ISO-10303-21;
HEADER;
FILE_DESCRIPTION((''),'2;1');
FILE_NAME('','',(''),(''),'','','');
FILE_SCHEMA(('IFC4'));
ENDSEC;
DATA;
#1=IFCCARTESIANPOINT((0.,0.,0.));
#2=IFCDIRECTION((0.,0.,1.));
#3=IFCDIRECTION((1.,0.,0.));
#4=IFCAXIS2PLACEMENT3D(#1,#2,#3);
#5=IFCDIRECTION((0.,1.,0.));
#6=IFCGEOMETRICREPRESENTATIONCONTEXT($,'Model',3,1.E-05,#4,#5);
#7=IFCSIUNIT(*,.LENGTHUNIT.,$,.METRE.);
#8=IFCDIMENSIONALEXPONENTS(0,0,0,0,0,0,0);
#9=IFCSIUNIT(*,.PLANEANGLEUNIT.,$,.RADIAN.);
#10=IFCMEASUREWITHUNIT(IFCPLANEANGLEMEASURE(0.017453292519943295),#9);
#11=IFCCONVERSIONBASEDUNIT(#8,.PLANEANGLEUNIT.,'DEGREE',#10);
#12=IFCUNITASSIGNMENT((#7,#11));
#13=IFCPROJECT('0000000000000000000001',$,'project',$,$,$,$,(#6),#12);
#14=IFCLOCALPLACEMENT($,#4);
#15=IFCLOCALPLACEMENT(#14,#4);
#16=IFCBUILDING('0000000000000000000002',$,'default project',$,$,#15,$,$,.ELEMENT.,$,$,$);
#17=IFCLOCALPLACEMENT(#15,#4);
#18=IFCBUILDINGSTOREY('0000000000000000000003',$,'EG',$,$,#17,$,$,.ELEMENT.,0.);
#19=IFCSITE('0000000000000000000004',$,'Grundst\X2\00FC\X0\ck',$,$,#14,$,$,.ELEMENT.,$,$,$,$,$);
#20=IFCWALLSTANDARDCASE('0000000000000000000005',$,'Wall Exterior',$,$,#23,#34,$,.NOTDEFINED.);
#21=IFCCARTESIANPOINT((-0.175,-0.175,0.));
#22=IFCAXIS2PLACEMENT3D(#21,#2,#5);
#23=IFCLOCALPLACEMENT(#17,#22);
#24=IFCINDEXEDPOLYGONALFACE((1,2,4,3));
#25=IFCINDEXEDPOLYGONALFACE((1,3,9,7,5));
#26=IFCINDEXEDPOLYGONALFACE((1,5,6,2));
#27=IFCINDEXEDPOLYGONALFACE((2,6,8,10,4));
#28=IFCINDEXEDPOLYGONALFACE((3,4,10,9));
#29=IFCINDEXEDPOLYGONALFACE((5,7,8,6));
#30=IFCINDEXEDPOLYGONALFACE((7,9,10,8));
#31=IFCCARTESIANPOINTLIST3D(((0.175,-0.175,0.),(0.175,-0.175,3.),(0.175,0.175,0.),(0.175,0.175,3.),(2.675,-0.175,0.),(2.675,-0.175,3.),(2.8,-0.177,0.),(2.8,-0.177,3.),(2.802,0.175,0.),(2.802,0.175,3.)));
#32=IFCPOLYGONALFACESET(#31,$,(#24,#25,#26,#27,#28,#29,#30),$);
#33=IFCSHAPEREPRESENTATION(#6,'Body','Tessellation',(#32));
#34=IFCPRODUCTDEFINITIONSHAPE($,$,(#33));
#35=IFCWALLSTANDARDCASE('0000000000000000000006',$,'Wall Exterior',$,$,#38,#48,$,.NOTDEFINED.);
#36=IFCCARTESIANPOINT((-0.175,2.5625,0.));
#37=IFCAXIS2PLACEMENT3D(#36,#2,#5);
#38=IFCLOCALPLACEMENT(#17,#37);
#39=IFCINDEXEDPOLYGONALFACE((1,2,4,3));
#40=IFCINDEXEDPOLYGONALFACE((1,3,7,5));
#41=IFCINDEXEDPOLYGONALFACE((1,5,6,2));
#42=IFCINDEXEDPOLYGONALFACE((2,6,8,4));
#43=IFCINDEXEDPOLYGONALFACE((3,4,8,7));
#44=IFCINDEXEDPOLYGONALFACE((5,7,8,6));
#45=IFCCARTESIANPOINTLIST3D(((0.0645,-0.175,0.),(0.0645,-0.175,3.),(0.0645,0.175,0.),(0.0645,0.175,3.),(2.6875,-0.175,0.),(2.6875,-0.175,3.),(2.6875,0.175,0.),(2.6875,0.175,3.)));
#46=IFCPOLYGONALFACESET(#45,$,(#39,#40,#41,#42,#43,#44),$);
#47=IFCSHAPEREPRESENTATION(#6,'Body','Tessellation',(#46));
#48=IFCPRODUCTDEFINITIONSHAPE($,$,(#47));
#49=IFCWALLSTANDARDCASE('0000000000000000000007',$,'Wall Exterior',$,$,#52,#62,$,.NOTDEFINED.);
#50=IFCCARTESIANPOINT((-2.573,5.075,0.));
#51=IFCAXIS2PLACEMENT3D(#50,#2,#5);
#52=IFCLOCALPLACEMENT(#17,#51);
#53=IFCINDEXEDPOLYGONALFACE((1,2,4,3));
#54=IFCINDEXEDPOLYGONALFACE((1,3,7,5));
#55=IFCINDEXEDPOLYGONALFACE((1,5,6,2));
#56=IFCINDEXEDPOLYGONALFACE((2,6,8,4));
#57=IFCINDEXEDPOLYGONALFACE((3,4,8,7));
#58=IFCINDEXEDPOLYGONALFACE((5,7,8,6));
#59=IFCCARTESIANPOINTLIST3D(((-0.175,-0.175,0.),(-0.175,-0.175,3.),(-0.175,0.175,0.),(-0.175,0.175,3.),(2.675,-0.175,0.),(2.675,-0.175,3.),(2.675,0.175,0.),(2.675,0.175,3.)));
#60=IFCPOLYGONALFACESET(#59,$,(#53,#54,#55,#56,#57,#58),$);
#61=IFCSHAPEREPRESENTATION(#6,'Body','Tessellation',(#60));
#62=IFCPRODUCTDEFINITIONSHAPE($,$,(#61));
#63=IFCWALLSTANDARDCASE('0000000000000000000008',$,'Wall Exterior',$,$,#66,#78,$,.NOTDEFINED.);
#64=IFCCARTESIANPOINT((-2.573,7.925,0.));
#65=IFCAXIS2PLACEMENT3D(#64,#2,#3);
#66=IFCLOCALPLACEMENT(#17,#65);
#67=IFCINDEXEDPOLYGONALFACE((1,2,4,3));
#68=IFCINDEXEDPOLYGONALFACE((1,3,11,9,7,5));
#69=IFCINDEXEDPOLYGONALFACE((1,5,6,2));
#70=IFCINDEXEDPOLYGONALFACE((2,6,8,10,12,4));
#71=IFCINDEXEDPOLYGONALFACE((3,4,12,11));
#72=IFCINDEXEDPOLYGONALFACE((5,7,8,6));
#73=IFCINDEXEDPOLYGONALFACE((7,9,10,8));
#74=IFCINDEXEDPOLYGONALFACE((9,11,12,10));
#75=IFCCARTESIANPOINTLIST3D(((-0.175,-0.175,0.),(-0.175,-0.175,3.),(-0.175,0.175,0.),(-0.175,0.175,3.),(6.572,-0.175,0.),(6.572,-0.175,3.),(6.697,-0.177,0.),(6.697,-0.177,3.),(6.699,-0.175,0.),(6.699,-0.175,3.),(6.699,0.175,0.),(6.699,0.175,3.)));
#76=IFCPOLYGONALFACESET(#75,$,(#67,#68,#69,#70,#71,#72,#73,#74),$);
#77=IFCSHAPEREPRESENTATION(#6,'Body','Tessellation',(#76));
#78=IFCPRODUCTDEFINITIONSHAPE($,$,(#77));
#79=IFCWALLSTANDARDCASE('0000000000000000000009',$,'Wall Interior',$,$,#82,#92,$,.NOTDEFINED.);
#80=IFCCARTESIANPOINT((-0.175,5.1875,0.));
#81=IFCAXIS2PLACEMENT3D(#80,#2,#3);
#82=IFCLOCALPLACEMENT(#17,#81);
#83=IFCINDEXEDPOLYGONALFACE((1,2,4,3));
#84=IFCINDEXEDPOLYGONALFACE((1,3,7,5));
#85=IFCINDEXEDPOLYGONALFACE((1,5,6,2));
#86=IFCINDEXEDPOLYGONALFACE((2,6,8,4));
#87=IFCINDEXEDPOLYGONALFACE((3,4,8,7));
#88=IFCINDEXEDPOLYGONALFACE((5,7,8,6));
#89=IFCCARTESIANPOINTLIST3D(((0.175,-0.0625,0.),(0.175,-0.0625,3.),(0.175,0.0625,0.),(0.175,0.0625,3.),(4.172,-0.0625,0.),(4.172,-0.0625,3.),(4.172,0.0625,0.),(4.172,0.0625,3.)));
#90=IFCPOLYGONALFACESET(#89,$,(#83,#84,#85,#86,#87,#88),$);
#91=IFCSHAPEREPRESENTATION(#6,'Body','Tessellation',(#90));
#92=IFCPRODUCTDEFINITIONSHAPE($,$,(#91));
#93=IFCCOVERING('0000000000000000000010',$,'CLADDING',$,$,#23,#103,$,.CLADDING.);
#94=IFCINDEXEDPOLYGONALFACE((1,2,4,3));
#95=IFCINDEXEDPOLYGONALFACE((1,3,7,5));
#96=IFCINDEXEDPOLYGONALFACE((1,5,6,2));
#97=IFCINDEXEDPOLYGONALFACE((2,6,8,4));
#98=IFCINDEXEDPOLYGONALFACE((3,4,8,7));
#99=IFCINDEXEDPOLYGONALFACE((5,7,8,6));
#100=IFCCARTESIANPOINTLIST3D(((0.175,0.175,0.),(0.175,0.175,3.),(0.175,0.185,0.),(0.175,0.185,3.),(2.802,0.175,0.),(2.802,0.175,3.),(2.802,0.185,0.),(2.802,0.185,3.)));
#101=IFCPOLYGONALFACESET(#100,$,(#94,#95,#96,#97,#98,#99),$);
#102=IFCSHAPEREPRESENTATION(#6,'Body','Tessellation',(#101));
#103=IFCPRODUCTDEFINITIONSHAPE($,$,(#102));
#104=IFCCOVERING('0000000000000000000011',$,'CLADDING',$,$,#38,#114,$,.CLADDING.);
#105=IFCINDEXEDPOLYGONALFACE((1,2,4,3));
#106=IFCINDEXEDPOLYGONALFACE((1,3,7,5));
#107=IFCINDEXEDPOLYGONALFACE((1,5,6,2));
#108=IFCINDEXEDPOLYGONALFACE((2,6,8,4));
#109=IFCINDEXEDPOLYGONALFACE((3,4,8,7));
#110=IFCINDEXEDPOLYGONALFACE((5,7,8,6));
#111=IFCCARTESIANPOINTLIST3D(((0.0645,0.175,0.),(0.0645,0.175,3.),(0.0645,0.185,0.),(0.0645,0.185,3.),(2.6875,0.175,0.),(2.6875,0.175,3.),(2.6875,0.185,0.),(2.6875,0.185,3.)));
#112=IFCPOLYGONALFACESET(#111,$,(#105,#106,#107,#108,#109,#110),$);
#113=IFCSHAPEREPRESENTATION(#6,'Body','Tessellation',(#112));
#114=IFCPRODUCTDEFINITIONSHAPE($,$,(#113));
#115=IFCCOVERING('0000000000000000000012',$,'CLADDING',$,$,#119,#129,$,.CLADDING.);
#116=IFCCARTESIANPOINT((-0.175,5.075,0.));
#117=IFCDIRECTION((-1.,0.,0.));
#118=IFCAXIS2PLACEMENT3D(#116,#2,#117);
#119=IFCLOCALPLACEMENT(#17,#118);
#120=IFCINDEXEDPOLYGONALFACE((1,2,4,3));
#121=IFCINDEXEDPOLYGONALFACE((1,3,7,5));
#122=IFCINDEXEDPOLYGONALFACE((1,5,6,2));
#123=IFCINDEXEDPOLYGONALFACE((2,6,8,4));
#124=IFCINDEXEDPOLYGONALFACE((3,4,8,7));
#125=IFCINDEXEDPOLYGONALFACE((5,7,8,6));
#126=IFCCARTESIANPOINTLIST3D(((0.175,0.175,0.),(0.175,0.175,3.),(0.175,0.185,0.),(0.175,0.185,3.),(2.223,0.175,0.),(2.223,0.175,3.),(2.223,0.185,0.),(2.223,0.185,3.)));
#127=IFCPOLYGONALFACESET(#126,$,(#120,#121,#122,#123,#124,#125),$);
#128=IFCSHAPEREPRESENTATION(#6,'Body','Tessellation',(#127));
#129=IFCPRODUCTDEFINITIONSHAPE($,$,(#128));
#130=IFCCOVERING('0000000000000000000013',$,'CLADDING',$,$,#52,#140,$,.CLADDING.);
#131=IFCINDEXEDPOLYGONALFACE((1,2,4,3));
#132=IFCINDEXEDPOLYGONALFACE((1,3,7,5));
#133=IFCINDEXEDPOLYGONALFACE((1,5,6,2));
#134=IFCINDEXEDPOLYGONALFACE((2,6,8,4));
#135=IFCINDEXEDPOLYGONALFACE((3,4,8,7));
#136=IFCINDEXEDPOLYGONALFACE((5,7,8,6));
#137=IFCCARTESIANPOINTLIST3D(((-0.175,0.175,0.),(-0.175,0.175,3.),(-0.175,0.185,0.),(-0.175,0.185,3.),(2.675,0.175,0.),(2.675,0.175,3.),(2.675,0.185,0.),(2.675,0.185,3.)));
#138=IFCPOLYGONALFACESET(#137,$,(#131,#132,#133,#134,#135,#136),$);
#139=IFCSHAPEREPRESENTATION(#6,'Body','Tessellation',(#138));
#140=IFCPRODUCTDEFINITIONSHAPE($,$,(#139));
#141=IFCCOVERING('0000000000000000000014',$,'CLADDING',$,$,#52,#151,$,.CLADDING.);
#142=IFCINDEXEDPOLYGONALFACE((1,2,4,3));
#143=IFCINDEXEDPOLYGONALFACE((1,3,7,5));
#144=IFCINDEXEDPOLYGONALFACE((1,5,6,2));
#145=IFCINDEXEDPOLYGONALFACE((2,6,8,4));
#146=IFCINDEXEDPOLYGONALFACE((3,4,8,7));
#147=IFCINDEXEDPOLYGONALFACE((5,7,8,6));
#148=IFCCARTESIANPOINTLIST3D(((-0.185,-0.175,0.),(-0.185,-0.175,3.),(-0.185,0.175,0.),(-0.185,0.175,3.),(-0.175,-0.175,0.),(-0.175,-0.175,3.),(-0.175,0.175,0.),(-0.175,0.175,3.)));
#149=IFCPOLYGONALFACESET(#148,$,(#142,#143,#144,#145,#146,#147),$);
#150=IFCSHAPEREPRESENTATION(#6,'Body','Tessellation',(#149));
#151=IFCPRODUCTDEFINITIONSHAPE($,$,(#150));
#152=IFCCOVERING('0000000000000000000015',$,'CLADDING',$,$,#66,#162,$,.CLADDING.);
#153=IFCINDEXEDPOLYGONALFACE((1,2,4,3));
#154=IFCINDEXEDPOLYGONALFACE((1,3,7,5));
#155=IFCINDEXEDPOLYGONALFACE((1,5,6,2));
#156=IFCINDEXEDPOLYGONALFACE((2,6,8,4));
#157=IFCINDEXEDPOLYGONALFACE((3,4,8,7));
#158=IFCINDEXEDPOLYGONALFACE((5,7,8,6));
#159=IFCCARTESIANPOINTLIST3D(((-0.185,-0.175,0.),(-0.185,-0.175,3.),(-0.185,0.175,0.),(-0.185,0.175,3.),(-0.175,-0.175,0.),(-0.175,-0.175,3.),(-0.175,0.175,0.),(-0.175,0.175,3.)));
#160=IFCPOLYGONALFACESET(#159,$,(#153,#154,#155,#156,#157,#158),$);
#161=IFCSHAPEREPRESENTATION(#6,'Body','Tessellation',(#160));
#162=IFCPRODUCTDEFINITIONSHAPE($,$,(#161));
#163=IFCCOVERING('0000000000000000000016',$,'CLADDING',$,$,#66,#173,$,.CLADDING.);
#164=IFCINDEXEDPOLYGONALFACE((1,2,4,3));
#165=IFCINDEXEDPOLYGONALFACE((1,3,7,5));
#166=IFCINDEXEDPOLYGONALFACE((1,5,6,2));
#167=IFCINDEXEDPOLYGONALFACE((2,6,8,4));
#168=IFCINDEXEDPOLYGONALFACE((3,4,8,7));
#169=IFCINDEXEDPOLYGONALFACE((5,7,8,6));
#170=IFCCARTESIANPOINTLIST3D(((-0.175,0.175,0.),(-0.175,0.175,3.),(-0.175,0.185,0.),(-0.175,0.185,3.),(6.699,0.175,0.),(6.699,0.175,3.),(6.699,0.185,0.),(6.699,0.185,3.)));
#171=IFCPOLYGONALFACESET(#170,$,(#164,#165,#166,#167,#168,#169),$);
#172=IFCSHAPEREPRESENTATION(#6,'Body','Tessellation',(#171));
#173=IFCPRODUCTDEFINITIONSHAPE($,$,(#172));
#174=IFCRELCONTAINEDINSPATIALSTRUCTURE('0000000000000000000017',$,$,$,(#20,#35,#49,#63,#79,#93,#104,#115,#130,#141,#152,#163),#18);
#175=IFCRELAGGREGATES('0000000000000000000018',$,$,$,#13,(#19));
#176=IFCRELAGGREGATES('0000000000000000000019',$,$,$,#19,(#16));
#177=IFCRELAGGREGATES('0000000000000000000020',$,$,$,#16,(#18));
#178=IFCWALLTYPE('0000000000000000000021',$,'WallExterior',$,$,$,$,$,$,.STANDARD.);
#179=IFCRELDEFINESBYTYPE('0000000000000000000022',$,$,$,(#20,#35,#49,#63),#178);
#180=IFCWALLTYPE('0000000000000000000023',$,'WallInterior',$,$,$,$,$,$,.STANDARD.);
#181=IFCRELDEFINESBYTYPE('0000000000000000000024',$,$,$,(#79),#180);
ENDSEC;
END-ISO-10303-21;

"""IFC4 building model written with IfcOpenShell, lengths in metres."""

from ifc_helpers import new_model, entity, si_unit, converted_unit, direction, frame, origin_with_axes, place, context, project, spatial, polyline, outline, extrude, type_object, element, save


model = new_model("IFC4")

# Units and contexts
model_context = context("Model", 3, precision=1e-05, world=origin_with_axes(), true_north=direction((0.0, 1.0, 0.0)))
ifc_project = project(units=[si_unit("LENGTHUNIT", "METRE"), converted_unit("PLANEANGLEUNIT", "DEGREE", entity("IfcPlaneAngleMeasure", 0.017453292519943295), si_unit("PLANEANGLEUNIT", "RADIAN"), dimensions=[0, 0, 0, 0, 0, 0, 0])], contexts=[model_context])

# Site, building, storey
site_placement = place(None, origin_with_axes())
site = spatial("IfcSite", under=ifc_project, at=site_placement, Name="Grundstück", CompositionType="ELEMENT")
building_placement = place(site_placement, origin_with_axes())
building = spatial("IfcBuilding", under=site, at=building_placement, Name="default project", CompositionType="ELEMENT")
placement_1 = place(building_placement, origin_with_axes())
storey = spatial("IfcBuildingStorey", under=building, at=placement_1, Name="EG", CompositionType="ELEMENT", Elevation=0.0)

# Walls
wall_type_1 = type_object("IfcWallType", Name="WallExterior", PredefinedType="STANDARD")
placement_2 = place(placement_1, frame((-0.175, -0.175, 0.0), z_axis=(0.0, 0.0, 1.0), x_axis=(0.0, 1.0, 0.0)))
element("IfcWallStandardCase", 1, at=placement_2, inside=storey, type_object=wall_type_1, Name="Wall Exterior", PredefinedType="NOTDEFINED", context=model_context, shape_type="SweptSolid", body=[
    extrude(outline(polyline([(2.802, 0.175), (0.175, 0.175), (0.175, -0.175), (2.675, -0.175), (2.8, -0.177), (2.802, 0.175)])), origin_with_axes(), (0.0, 0.0, 1.0), 3.0),
])
placement_3 = place(placement_1, frame((-0.175, 2.5625, 0.0), z_axis=(0.0, 0.0, 1.0), x_axis=(0.0, 1.0, 0.0)))
element("IfcWallStandardCase", 2, at=placement_3, inside=storey, type_object=wall_type_1, Name="Wall Exterior", PredefinedType="NOTDEFINED", context=model_context, shape_type="SweptSolid", body=[
    extrude(outline(polyline([(0.0645, -0.175), (2.6875, -0.175), (2.6875, 0.175), (0.0645, 0.175), (0.0645, -0.175)])), origin_with_axes(), (0.0, 0.0, 1.0), 3.0),
])
placement_4 = place(placement_1, frame((-0.175, 5.075, 0.0), z_axis=(0.0, 0.0, 1.0), x_axis=(-1.0, 0.0, 0.0)))
placement_5 = place(placement_1, frame((-2.573, 5.075, 0.0), z_axis=(0.0, 0.0, 1.0), x_axis=(0.0, 1.0, 0.0)))
element("IfcWallStandardCase", 3, at=placement_5, inside=storey, type_object=wall_type_1, Name="Wall Exterior", PredefinedType="NOTDEFINED", context=model_context, shape_type="SweptSolid", body=[
    extrude(outline(polyline([(2.675, -0.175), (2.675, 0.175), (-0.175, 0.175), (-0.175, -0.175), (2.675, -0.175)])), origin_with_axes(), (0.0, 0.0, 1.0), 3.0),
])
placement_6 = place(placement_1, frame((-2.573, 7.925, 0.0), z_axis=(0.0, 0.0, 1.0), x_axis=(1.0, 0.0, 0.0)))
element("IfcWallStandardCase", 4, at=placement_6, inside=storey, type_object=wall_type_1, Name="Wall Exterior", PredefinedType="NOTDEFINED", context=model_context, shape_type="SweptSolid", body=[
    extrude(outline(polyline([(-0.175, 0.175), (-0.175, -0.175), (6.572, -0.175), (6.697, -0.177), (6.699, -0.175), (6.699, 0.175), (-0.175, 0.175)])), origin_with_axes(), (0.0, 0.0, 1.0), 3.0),
])
wall_type_2 = type_object("IfcWallType", Name="WallInterior", PredefinedType="STANDARD")
wall_1_placement = place(placement_1, frame((-0.175, 5.1875, 0.0), z_axis=(0.0, 0.0, 1.0), x_axis=(1.0, 0.0, 0.0)))
element("IfcWallStandardCase", 5, at=wall_1_placement, inside=storey, type_object=wall_type_2, Name="Wall Interior", PredefinedType="NOTDEFINED", context=model_context, shape_type="SweptSolid", body=[
    extrude(outline(polyline([(4.172, 0.0625), (0.175, 0.0625), (0.175, -0.0625), (4.172, -0.0625), (4.172, 0.0625)])), origin_with_axes(), (0.0, 0.0, 1.0), 3.0),
])

# Coverings
element("IfcCovering", 6, at=placement_2, inside=storey, Name="CLADDING", PredefinedType="CLADDING", context=model_context, shape_type="SweptSolid", body=[
    extrude(outline(polyline([(2.802, 0.185), (0.175, 0.185), (0.175, 0.175), (2.802, 0.175), (2.802, 0.185)])), origin_with_axes(), (0.0, 0.0, 1.0), 3.0),
])
element("IfcCovering", 7, at=placement_3, inside=storey, Name="CLADDING", PredefinedType="CLADDING", context=model_context, shape_type="SweptSolid", body=[
    extrude(outline(polyline([(2.6875, 0.185), (0.0645, 0.185), (0.0645, 0.175), (2.6875, 0.175), (2.6875, 0.185)])), origin_with_axes(), (0.0, 0.0, 1.0), 3.0),
])
element("IfcCovering", 8, at=placement_4, inside=storey, Name="CLADDING", PredefinedType="CLADDING", context=model_context, shape_type="SweptSolid", body=[
    extrude(outline(polyline([(2.223, 0.185), (0.175, 0.185), (0.175, 0.175), (2.223, 0.175), (2.223, 0.185)])), origin_with_axes(), (0.0, 0.0, 1.0), 3.0),
])
element("IfcCovering", 9, at=placement_5, inside=storey, Name="CLADDING", PredefinedType="CLADDING", context=model_context, shape_type="SweptSolid", body=[
    extrude(outline(polyline([(2.675, 0.185), (-0.175, 0.185), (-0.175, 0.175), (2.675, 0.175), (2.675, 0.185)])), origin_with_axes(), (0.0, 0.0, 1.0), 3.0),
])
element("IfcCovering", 10, at=placement_5, inside=storey, Name="CLADDING", PredefinedType="CLADDING", context=model_context, shape_type="SweptSolid", body=[
    extrude(outline(polyline([(-0.185, 0.175), (-0.185, -0.175), (-0.175, -0.175), (-0.175, 0.175), (-0.185, 0.175)])), origin_with_axes(), (0.0, 0.0, 1.0), 3.0),
])
element("IfcCovering", 11, at=placement_6, inside=storey, Name="CLADDING", PredefinedType="CLADDING", context=model_context, shape_type="SweptSolid", body=[
    extrude(outline(polyline([(-0.185, 0.175), (-0.185, -0.175), (-0.175, -0.175), (-0.175, 0.175), (-0.185, 0.175)])), origin_with_axes(), (0.0, 0.0, 1.0), 3.0),
])
element("IfcCovering", 12, at=placement_6, inside=storey, Name="CLADDING", PredefinedType="CLADDING", context=model_context, shape_type="SweptSolid", body=[
    extrude(outline(polyline([(6.699, 0.185), (-0.175, 0.185), (-0.175, 0.175), (6.699, 0.175), (6.699, 0.185)])), origin_with_axes(), (0.0, 0.0, 1.0), 3.0),
])

save(model, "model.ifc")
